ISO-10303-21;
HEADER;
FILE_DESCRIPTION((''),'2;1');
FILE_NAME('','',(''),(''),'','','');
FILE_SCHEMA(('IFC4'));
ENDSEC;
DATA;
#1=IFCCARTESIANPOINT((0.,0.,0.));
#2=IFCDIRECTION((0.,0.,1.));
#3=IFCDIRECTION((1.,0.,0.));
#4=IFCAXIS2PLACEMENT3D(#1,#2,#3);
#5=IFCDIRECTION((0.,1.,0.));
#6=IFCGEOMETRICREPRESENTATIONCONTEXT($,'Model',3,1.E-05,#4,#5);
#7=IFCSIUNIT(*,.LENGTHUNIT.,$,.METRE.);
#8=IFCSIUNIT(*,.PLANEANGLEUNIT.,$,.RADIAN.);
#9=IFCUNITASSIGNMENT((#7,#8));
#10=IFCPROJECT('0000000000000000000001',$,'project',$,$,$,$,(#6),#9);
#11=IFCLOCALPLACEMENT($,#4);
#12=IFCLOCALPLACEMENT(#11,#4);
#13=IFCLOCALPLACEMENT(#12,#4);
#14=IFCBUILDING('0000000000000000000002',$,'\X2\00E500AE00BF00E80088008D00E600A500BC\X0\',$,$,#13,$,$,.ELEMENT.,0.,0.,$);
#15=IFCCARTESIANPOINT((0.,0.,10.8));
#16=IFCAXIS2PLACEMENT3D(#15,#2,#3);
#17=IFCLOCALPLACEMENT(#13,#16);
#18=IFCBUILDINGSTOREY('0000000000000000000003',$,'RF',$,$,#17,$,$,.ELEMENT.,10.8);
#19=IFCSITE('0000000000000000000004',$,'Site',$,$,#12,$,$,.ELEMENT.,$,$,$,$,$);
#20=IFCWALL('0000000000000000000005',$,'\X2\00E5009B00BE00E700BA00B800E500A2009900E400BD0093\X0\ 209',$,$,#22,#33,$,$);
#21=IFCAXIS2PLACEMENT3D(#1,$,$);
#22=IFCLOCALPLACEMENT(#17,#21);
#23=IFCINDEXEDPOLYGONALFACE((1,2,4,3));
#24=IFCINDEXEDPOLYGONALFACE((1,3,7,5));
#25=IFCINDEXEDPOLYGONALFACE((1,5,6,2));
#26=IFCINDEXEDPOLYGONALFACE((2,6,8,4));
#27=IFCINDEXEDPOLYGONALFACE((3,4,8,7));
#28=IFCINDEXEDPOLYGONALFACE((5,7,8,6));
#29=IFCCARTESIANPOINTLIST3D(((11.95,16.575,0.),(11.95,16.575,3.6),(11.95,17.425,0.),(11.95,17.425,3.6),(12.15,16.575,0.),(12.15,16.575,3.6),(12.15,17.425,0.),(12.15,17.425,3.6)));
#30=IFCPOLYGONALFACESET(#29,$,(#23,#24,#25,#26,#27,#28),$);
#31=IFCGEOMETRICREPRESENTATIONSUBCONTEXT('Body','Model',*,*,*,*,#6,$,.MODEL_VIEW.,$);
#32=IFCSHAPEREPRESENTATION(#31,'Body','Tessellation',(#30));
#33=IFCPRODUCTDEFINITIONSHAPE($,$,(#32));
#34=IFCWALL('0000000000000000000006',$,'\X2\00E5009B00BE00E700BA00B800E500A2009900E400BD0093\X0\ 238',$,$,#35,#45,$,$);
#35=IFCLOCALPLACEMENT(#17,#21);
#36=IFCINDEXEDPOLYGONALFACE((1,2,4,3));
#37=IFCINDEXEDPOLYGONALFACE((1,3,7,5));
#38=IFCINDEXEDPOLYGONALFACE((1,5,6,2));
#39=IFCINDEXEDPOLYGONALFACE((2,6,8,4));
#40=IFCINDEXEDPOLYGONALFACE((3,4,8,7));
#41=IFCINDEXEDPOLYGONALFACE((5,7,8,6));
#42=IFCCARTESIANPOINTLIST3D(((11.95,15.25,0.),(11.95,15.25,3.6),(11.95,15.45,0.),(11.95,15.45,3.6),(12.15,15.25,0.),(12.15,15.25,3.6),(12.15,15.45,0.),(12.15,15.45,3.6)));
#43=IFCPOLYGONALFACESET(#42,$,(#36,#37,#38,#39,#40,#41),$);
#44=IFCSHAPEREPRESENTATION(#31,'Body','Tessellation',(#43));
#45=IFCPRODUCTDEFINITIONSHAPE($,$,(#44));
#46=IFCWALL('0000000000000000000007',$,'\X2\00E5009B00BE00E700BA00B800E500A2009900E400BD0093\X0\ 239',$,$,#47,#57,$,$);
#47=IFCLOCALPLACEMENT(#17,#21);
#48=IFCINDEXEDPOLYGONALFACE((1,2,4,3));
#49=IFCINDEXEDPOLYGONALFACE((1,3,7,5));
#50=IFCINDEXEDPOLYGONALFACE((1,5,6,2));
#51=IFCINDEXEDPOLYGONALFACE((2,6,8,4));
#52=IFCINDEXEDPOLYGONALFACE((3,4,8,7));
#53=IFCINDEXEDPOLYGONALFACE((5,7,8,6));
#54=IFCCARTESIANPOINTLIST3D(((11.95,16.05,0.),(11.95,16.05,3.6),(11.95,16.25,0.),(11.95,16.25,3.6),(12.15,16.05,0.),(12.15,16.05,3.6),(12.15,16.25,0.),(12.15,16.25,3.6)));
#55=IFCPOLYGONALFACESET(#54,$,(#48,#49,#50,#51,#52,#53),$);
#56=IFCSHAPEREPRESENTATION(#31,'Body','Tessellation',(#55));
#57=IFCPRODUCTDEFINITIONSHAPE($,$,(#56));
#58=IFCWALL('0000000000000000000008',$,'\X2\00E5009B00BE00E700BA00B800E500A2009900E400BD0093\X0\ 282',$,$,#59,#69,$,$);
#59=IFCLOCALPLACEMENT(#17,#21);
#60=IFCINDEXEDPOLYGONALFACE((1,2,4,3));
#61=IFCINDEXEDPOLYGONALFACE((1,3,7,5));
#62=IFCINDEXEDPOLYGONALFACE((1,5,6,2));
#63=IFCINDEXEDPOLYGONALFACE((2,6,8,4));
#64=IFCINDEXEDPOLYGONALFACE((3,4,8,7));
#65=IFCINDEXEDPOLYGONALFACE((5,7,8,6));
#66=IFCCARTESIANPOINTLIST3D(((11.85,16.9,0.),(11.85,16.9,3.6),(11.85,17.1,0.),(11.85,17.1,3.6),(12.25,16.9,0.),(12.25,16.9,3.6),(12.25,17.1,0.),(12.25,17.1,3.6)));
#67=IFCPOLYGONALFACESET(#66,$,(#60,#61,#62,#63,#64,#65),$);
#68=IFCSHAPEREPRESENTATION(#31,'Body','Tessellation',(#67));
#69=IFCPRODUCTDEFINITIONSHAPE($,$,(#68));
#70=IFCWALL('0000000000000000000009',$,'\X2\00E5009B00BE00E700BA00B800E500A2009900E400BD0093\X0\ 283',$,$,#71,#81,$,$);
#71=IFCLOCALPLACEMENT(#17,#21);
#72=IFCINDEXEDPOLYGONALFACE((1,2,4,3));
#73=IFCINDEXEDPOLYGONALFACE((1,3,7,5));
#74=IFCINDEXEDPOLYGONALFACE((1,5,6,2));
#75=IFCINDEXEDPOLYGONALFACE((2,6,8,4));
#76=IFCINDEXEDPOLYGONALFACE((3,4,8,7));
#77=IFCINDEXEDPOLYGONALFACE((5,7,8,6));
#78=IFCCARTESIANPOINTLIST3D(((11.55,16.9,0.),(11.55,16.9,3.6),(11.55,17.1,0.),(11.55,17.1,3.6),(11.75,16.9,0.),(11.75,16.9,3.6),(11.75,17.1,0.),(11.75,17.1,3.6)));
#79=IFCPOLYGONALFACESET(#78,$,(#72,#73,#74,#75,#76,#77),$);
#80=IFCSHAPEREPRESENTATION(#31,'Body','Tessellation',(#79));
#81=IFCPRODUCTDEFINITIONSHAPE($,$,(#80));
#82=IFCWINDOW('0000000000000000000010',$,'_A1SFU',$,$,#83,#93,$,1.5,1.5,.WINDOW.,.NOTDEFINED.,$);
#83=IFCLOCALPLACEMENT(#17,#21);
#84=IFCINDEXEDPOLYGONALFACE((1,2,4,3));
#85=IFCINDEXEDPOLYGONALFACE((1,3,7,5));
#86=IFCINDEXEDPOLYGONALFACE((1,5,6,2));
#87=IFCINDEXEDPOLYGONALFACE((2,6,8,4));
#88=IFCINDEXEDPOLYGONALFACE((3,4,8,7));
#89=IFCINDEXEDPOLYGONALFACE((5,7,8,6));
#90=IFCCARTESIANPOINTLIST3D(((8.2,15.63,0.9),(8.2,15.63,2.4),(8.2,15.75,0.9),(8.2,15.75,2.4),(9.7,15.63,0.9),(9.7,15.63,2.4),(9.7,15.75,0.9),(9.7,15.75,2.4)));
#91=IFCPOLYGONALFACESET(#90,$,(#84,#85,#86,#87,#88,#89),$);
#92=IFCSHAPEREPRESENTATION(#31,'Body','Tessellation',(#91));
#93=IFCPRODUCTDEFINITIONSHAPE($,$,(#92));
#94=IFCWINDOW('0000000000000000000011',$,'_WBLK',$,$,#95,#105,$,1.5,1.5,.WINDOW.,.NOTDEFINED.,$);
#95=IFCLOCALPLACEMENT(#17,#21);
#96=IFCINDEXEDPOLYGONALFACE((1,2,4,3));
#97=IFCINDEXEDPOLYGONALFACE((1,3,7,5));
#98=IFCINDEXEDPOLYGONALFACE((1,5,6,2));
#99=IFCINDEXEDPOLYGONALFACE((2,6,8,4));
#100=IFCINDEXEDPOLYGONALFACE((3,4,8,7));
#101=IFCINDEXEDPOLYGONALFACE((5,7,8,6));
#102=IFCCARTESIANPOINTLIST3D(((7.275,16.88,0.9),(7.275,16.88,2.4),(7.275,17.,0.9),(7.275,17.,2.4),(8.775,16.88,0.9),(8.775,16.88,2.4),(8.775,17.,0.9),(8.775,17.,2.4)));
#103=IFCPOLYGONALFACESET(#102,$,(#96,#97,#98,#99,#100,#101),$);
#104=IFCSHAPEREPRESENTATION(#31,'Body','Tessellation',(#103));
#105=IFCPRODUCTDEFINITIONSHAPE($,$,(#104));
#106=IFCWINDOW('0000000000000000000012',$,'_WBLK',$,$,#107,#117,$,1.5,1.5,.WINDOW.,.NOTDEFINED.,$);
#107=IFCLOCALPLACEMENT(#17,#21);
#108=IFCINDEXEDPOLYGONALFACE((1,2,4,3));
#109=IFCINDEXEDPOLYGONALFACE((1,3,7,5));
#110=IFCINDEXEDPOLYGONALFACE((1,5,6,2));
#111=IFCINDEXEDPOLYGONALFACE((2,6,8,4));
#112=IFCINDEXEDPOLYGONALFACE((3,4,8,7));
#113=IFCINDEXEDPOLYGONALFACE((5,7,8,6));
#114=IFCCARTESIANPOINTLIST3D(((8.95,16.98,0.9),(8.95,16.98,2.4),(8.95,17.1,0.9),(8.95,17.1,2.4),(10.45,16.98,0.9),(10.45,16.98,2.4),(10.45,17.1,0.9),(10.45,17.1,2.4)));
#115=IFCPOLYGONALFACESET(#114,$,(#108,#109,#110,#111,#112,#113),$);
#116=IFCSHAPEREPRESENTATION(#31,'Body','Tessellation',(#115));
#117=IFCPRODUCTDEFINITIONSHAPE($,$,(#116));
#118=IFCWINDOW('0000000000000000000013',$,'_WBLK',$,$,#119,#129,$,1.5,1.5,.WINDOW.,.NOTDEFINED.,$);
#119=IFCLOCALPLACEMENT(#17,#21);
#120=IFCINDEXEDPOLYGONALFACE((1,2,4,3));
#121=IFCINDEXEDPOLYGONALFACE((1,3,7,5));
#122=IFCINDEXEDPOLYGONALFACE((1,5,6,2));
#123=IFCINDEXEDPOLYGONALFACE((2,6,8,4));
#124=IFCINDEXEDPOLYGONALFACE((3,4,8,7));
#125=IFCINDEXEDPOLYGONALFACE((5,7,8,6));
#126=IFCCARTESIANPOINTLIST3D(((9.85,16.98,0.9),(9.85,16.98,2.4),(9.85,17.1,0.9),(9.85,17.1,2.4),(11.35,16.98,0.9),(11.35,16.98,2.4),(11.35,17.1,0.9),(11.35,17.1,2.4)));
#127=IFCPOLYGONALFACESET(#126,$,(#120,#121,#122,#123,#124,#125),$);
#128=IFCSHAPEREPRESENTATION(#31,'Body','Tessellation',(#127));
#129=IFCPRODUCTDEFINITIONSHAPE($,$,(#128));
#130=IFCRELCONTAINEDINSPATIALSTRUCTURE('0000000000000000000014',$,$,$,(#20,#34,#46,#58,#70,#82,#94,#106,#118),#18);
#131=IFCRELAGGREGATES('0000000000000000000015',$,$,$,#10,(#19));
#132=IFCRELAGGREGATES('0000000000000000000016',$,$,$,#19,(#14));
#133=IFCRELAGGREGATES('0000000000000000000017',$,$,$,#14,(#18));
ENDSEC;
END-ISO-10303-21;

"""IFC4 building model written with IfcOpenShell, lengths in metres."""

from ifc_helpers import new_model, si_unit, direction, frame, frame_2d, origin_with_axes, place, context, subcontext, project, spatial, rectangle, extrude, element, save


model = new_model("IFC4")

# Units and contexts
model_context = context("Model", 3, precision=1e-05, world=origin_with_axes(), true_north=direction((0.0, 1.0, 0.0)))
body_context = subcontext(model_context, "Body", "Model", "MODEL_VIEW")
ifc_project = project(units=[si_unit("LENGTHUNIT", "METRE"), si_unit("PLANEANGLEUNIT", "RADIAN")], contexts=[model_context])

# Site, building, storey
placement = place(None, origin_with_axes())
site_placement = place(placement, origin_with_axes())
site = spatial("IfcSite", under=ifc_project, at=site_placement, Name="Site", CompositionType="ELEMENT")
building_placement = place(site_placement, origin_with_axes())
building = spatial("IfcBuilding", under=site, at=building_placement, Name="å®¿è\u0088\u008dæ¥¼", CompositionType="ELEMENT", ElevationOfRefHeight=0.0, ElevationOfTerrain=0.0)
storey_placement = place(building_placement, frame((0.0, 0.0, 10.8), z_axis=(0.0, 0.0, 1.0), x_axis=(1.0, 0.0, 0.0)))
storey = spatial("IfcBuildingStorey", under=building, at=storey_placement, Name="RF", CompositionType="ELEMENT", Elevation=10.8)

# Walls
for number, where, z_axis, x_axis, name in (
    (1, (12.05, 17.0, 0.0), (0.0, 0.0, 1.0), (0.0, -1.0, 0.0), "å\u009b¾çº¸å¢\u0099ä½\u0093 209"),
):
    element("IfcWall", number, at=place(storey_placement, frame(where, z_axis=z_axis, x_axis=x_axis)), inside=storey, Name=name, context=body_context, shape_type="SweptSolid", body=[
        extrude(rectangle(XDim=0.85, YDim=0.2, at=frame_2d((0.0, 0.0), x_axis=(1.0, 0.0, 0.0))), frame((0.0, 0.0, 0.0), z_axis=(0.0, 0.0, 1.0)), (0.0, 0.0, 1.0), 3.6),
    ])
for number, where, z_axis, x_axis, name in (
    (2, (12.05, 15.35, 0.0), (0.0, 0.0, 1.0), (0.0, -1.0, 0.0), "å\u009b¾çº¸å¢\u0099ä½\u0093 238"),
    (3, (12.05, 16.15, 0.0), (0.0, 0.0, 1.0), (1.0, 0.0, 0.0), "å\u009b¾çº¸å¢\u0099ä½\u0093 239"),
):
    element("IfcWall", number, at=place(storey_placement, frame(where, z_axis=z_axis, x_axis=x_axis)), inside=storey, Name=name, context=body_context, shape_type="SweptSolid", body=[
        extrude(rectangle(XDim=0.2, YDim=0.2, at=frame_2d((0.0, 0.0), x_axis=(1.0, 0.0, 0.0))), frame((0.0, 0.0, 0.0), z_axis=(0.0, 0.0, 1.0)), (0.0, 0.0, 1.0), 3.6),
    ])
wall_1_placement = place(storey_placement, frame((12.05, 17.0, 0.0), z_axis=(0.0, 0.0, 1.0), x_axis=(-1.0, 0.0, 0.0)))
element("IfcWall", 4, at=wall_1_placement, inside=storey, Name="å\u009b¾çº¸å¢\u0099ä½\u0093 282", context=body_context, shape_type="SweptSolid", body=[
    extrude(rectangle(XDim=0.4, YDim=0.2, at=frame_2d((0.0, 0.0), x_axis=(1.0, 0.0, 0.0))), frame((0.0, 0.0, 0.0), z_axis=(0.0, 0.0, 1.0)), (0.0, 0.0, 1.0), 3.6),
])
for number, where, z_axis, x_axis, name in (
    (5, (11.65, 17.0, 0.0), (0.0, 0.0, 1.0), (0.0, 1.0, 0.0), "å\u009b¾çº¸å¢\u0099ä½\u0093 283"),
):
    element("IfcWall", number, at=place(storey_placement, frame(where, z_axis=z_axis, x_axis=x_axis)), inside=storey, Name=name, context=body_context, shape_type="SweptSolid", body=[
        extrude(rectangle(XDim=0.2, YDim=0.2, at=frame_2d((0.0, 0.0), x_axis=(1.0, 0.0, 0.0))), frame((0.0, 0.0, 0.0), z_axis=(0.0, 0.0, 1.0)), (0.0, 0.0, 1.0), 3.6),
    ])

# Windows
for number, where, z_axis, x_axis, name in (
    (6, (8.95, 15.69, 0.9), (0.0, 0.0, 1.0), (1.0, 0.0, 0.0), "_A1SFU"),
    (7, (8.025, 16.94, 0.9), (0.0, 0.0, 1.0), (1.0, 0.0, 0.0), "_WBLK"),
    (8, (9.7, 17.04, 0.9), (0.0, 0.0, 1.0), (1.0, 0.0, 0.0), "_WBLK"),
    (9, (10.6, 17.04, 0.9), (0.0, 0.0, 1.0), (1.0, 0.0, 0.0), "_WBLK"),
):
    element("IfcWindow", number, at=place(storey_placement, frame(where, z_axis=z_axis, x_axis=x_axis)), inside=storey, Name=name, OverallHeight=1.5, OverallWidth=1.5, PartitioningType="NOTDEFINED", PredefinedType="WINDOW", context=body_context, shape_type="SweptSolid", body=[
        extrude(rectangle(XDim=1.5, YDim=0.12, at=frame_2d((0.0, 0.0), x_axis=(1.0, 0.0, 0.0))), frame((0.0, 0.0, 0.0), z_axis=(0.0, 0.0, 1.0)), (0.0, 0.0, 1.0), 1.5),
    ])

save(model, "model.ifc")
